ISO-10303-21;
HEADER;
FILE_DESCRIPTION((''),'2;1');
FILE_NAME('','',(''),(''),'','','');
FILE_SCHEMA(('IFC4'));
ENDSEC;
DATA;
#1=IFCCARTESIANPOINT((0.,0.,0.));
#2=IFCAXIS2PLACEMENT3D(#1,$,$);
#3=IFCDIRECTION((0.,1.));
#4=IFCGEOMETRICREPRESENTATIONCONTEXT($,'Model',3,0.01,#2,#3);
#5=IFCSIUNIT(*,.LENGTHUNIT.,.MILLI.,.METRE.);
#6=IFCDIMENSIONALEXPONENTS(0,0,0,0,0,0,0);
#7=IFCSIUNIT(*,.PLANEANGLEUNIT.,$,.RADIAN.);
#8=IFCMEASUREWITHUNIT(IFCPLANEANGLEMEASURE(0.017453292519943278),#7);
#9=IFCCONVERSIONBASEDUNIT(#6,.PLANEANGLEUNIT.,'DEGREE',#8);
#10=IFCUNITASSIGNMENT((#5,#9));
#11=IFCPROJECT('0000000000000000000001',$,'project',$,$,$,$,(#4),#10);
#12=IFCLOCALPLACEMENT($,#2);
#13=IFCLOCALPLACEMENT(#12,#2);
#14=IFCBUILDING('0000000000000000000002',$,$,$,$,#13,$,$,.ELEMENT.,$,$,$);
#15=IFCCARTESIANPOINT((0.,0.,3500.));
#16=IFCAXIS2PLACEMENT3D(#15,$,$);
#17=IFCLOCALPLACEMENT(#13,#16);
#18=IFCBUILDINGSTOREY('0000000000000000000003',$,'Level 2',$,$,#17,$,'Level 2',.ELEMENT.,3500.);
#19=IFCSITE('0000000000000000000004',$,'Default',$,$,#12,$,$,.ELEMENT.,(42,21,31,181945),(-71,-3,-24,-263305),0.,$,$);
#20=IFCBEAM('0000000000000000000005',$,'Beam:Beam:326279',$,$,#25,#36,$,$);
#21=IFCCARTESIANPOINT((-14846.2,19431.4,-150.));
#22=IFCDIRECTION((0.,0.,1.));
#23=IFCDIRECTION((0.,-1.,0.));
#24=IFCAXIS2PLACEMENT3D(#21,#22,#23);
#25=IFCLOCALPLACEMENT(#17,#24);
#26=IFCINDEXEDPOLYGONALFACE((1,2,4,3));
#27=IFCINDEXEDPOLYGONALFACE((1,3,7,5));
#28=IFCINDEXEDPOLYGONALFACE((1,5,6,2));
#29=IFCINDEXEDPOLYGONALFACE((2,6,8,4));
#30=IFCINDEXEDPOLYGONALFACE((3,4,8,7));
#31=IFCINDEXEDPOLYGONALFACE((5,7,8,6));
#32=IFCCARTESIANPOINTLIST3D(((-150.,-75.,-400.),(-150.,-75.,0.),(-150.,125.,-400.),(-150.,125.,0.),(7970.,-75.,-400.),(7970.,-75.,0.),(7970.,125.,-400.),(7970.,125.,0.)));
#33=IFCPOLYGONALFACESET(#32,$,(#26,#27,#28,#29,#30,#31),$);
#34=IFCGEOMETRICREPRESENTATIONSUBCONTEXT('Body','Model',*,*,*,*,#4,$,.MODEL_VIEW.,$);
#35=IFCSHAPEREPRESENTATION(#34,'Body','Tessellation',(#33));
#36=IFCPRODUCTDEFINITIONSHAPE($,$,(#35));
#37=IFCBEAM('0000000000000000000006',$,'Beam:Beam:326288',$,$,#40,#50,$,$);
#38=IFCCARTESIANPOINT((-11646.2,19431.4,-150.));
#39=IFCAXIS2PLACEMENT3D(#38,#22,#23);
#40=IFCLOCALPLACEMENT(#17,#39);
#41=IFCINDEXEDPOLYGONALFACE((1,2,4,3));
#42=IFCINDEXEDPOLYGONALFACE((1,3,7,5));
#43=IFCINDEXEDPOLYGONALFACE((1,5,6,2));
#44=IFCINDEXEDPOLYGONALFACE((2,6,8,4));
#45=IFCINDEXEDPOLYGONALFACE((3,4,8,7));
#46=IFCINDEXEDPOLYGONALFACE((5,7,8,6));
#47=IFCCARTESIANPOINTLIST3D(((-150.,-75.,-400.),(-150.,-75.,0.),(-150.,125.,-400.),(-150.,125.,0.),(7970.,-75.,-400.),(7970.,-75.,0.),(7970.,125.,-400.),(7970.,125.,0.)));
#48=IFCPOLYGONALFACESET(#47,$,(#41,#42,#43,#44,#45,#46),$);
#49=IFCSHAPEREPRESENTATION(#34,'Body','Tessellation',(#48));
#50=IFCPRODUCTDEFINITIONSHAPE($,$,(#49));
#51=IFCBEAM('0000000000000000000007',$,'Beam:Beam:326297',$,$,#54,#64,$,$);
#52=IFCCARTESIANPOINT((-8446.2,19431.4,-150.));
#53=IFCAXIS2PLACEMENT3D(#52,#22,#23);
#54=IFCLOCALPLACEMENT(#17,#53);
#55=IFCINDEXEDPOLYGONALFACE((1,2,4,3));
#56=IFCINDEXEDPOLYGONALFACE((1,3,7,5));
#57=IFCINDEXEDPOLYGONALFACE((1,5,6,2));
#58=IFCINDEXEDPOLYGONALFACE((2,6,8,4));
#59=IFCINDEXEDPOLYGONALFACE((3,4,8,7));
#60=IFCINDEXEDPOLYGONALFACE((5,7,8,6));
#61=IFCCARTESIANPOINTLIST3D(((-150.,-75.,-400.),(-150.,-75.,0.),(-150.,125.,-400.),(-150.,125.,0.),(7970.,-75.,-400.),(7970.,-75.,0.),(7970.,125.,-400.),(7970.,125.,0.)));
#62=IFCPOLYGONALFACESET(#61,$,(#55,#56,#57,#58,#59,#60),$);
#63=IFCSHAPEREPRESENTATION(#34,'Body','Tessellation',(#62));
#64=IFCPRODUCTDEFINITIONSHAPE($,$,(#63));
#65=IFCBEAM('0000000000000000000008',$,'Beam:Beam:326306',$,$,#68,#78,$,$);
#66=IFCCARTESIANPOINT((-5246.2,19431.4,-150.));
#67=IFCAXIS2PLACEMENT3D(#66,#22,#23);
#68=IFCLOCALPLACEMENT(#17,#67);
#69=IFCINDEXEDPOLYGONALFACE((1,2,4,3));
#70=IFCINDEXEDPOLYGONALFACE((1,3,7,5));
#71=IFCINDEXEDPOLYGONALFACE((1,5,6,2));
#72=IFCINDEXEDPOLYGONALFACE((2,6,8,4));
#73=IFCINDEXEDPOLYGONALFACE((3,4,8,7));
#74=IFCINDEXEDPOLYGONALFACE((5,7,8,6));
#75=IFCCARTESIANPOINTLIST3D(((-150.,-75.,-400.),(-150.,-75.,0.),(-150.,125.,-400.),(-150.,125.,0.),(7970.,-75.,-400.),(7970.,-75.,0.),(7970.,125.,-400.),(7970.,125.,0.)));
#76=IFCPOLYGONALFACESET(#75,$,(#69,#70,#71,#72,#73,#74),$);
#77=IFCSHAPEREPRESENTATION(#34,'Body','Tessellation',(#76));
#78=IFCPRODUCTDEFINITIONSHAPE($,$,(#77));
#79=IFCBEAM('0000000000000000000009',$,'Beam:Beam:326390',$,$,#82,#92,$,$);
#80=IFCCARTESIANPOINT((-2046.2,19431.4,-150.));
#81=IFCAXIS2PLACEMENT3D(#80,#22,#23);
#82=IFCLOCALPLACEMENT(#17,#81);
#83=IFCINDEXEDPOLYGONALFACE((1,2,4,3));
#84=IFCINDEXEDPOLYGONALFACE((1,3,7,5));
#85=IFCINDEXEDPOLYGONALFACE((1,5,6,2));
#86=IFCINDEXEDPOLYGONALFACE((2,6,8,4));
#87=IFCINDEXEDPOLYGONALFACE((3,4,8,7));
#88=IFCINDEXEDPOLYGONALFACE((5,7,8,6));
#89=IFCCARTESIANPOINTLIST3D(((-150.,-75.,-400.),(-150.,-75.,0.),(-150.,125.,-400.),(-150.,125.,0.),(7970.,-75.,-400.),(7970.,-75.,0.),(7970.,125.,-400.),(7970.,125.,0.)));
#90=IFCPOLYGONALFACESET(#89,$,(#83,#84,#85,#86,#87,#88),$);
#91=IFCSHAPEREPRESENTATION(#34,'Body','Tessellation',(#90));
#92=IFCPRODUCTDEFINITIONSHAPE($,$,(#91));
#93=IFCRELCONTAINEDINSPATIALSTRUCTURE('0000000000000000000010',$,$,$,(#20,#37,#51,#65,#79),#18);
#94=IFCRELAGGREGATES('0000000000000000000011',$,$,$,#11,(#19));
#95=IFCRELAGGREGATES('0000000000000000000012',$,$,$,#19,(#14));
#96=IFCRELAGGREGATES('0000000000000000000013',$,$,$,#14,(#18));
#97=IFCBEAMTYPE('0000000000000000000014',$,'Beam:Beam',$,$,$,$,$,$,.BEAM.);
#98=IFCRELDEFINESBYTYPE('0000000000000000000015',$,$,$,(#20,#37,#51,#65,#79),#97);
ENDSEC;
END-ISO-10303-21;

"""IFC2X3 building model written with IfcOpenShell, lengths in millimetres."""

from ifc_helpers import new_model, entity, si_unit, converted_unit, direction, frame, frame_2d, origin, place, context, subcontext, project, spatial, rectangle, extrude, type_object, element, save


model = new_model("IFC2X3")

# Units and contexts
model_context = context("Model", 3, precision=0.01, world=origin(), true_north=direction((0.0, 1.0)))
body_context = subcontext(model_context, "Body", "Model", "MODEL_VIEW")
ifc_project = project(units=[si_unit("LENGTHUNIT", "METRE", prefix="MILLI"), converted_unit("PLANEANGLEUNIT", "DEGREE", entity("IfcPlaneAngleMeasure", 0.017453292519943278), si_unit("PLANEANGLEUNIT", "RADIAN"), dimensions=[0, 0, 0, 0, 0, 0, 0])], contexts=[model_context])

# Site, building, storey
site_placement = place(None, origin())
site = spatial("IfcSite", under=ifc_project, at=site_placement, Name="Default", CompositionType="ELEMENT", RefLatitude=(42, 21, 31, 181945), RefLongitude=(-71, -3, -24, -263305), RefElevation=0.0)
building_placement = place(site_placement, origin())
building = spatial("IfcBuilding", under=site, at=building_placement, CompositionType="ELEMENT")
storey_placement = place(building_placement, frame((0.0, 0.0, 3500.0)))
storey = spatial("IfcBuildingStorey", under=building, at=storey_placement, Name="Level 2", LongName="Level 2", CompositionType="ELEMENT", Elevation=3500.0)

# Beams
beam_type = type_object("IfcBeamType", Name="Beam:Beam", PredefinedType="BEAM")
for number, where, z_axis, x_axis, name in (
    (1, (-14846.2, 19431.4, -150.0), (0.0, 0.0, 1.0), (0.0, -1.0, 0.0), "Beam:Beam:326279"),
    (2, (-11646.2, 19431.4, -150.0), (0.0, 0.0, 1.0), (0.0, -1.0, 0.0), "Beam:Beam:326288"),
    (3, (-8446.2, 19431.4, -150.0), (0.0, 0.0, 1.0), (0.0, -1.0, 0.0), "Beam:Beam:326297"),
):
    element("IfcBeam", number, at=place(storey_placement, frame(where, z_axis=z_axis, x_axis=x_axis)), inside=storey, type_object=beam_type, Name=name, context=body_context, shape_type="SweptSolid", body=[
        extrude(rectangle(XDim=400.0, YDim=200.0, at=frame_2d((0.0, 0.0), x_axis=(1.0, 0.0))), frame((-150.0, 25.0, -200.0), z_axis=(1.0, 0.0, 0.0), x_axis=(0.0, 0.0, -1.0)), (0.0, 0.0, 1.0), 8120.0),
    ])
beam_1_placement = place(storey_placement, frame((-5246.2, 19431.4, -150.0), z_axis=(0.0, 0.0, 1.0), x_axis=(0.0, -1.0, 0.0)))
element("IfcBeam", 4, at=beam_1_placement, inside=storey, type_object=beam_type, Name="Beam:Beam:326306", context=body_context, shape_type="SweptSolid", body=[
    extrude(rectangle(XDim=400.0, YDim=200.0, at=frame_2d((0.0, 0.0), x_axis=(1.0, 0.0))), frame((-150.0, 25.0, -200.0), z_axis=(1.0, 0.0, 0.0), x_axis=(0.0, 0.0, -1.0)), (0.0, 0.0, 1.0), 8120.0),
])
beam_2_placement = place(storey_placement, frame((-2046.2, 19431.4, -150.0), z_axis=(0.0, 0.0, 1.0), x_axis=(0.0, -1.0, 0.0)))
element("IfcBeam", 5, at=beam_2_placement, inside=storey, type_object=beam_type, Name="Beam:Beam:326390", context=body_context, shape_type="SweptSolid", body=[
    extrude(rectangle(XDim=400.0, YDim=200.0, at=frame_2d((0.0, 0.0), x_axis=(1.0, 0.0))), frame((-150.0, 25.0, -200.0), z_axis=(1.0, 0.0, 0.0), x_axis=(0.0, 0.0, -1.0)), (0.0, 0.0, 1.0), 8120.0),
])

save(model, "model.ifc")
